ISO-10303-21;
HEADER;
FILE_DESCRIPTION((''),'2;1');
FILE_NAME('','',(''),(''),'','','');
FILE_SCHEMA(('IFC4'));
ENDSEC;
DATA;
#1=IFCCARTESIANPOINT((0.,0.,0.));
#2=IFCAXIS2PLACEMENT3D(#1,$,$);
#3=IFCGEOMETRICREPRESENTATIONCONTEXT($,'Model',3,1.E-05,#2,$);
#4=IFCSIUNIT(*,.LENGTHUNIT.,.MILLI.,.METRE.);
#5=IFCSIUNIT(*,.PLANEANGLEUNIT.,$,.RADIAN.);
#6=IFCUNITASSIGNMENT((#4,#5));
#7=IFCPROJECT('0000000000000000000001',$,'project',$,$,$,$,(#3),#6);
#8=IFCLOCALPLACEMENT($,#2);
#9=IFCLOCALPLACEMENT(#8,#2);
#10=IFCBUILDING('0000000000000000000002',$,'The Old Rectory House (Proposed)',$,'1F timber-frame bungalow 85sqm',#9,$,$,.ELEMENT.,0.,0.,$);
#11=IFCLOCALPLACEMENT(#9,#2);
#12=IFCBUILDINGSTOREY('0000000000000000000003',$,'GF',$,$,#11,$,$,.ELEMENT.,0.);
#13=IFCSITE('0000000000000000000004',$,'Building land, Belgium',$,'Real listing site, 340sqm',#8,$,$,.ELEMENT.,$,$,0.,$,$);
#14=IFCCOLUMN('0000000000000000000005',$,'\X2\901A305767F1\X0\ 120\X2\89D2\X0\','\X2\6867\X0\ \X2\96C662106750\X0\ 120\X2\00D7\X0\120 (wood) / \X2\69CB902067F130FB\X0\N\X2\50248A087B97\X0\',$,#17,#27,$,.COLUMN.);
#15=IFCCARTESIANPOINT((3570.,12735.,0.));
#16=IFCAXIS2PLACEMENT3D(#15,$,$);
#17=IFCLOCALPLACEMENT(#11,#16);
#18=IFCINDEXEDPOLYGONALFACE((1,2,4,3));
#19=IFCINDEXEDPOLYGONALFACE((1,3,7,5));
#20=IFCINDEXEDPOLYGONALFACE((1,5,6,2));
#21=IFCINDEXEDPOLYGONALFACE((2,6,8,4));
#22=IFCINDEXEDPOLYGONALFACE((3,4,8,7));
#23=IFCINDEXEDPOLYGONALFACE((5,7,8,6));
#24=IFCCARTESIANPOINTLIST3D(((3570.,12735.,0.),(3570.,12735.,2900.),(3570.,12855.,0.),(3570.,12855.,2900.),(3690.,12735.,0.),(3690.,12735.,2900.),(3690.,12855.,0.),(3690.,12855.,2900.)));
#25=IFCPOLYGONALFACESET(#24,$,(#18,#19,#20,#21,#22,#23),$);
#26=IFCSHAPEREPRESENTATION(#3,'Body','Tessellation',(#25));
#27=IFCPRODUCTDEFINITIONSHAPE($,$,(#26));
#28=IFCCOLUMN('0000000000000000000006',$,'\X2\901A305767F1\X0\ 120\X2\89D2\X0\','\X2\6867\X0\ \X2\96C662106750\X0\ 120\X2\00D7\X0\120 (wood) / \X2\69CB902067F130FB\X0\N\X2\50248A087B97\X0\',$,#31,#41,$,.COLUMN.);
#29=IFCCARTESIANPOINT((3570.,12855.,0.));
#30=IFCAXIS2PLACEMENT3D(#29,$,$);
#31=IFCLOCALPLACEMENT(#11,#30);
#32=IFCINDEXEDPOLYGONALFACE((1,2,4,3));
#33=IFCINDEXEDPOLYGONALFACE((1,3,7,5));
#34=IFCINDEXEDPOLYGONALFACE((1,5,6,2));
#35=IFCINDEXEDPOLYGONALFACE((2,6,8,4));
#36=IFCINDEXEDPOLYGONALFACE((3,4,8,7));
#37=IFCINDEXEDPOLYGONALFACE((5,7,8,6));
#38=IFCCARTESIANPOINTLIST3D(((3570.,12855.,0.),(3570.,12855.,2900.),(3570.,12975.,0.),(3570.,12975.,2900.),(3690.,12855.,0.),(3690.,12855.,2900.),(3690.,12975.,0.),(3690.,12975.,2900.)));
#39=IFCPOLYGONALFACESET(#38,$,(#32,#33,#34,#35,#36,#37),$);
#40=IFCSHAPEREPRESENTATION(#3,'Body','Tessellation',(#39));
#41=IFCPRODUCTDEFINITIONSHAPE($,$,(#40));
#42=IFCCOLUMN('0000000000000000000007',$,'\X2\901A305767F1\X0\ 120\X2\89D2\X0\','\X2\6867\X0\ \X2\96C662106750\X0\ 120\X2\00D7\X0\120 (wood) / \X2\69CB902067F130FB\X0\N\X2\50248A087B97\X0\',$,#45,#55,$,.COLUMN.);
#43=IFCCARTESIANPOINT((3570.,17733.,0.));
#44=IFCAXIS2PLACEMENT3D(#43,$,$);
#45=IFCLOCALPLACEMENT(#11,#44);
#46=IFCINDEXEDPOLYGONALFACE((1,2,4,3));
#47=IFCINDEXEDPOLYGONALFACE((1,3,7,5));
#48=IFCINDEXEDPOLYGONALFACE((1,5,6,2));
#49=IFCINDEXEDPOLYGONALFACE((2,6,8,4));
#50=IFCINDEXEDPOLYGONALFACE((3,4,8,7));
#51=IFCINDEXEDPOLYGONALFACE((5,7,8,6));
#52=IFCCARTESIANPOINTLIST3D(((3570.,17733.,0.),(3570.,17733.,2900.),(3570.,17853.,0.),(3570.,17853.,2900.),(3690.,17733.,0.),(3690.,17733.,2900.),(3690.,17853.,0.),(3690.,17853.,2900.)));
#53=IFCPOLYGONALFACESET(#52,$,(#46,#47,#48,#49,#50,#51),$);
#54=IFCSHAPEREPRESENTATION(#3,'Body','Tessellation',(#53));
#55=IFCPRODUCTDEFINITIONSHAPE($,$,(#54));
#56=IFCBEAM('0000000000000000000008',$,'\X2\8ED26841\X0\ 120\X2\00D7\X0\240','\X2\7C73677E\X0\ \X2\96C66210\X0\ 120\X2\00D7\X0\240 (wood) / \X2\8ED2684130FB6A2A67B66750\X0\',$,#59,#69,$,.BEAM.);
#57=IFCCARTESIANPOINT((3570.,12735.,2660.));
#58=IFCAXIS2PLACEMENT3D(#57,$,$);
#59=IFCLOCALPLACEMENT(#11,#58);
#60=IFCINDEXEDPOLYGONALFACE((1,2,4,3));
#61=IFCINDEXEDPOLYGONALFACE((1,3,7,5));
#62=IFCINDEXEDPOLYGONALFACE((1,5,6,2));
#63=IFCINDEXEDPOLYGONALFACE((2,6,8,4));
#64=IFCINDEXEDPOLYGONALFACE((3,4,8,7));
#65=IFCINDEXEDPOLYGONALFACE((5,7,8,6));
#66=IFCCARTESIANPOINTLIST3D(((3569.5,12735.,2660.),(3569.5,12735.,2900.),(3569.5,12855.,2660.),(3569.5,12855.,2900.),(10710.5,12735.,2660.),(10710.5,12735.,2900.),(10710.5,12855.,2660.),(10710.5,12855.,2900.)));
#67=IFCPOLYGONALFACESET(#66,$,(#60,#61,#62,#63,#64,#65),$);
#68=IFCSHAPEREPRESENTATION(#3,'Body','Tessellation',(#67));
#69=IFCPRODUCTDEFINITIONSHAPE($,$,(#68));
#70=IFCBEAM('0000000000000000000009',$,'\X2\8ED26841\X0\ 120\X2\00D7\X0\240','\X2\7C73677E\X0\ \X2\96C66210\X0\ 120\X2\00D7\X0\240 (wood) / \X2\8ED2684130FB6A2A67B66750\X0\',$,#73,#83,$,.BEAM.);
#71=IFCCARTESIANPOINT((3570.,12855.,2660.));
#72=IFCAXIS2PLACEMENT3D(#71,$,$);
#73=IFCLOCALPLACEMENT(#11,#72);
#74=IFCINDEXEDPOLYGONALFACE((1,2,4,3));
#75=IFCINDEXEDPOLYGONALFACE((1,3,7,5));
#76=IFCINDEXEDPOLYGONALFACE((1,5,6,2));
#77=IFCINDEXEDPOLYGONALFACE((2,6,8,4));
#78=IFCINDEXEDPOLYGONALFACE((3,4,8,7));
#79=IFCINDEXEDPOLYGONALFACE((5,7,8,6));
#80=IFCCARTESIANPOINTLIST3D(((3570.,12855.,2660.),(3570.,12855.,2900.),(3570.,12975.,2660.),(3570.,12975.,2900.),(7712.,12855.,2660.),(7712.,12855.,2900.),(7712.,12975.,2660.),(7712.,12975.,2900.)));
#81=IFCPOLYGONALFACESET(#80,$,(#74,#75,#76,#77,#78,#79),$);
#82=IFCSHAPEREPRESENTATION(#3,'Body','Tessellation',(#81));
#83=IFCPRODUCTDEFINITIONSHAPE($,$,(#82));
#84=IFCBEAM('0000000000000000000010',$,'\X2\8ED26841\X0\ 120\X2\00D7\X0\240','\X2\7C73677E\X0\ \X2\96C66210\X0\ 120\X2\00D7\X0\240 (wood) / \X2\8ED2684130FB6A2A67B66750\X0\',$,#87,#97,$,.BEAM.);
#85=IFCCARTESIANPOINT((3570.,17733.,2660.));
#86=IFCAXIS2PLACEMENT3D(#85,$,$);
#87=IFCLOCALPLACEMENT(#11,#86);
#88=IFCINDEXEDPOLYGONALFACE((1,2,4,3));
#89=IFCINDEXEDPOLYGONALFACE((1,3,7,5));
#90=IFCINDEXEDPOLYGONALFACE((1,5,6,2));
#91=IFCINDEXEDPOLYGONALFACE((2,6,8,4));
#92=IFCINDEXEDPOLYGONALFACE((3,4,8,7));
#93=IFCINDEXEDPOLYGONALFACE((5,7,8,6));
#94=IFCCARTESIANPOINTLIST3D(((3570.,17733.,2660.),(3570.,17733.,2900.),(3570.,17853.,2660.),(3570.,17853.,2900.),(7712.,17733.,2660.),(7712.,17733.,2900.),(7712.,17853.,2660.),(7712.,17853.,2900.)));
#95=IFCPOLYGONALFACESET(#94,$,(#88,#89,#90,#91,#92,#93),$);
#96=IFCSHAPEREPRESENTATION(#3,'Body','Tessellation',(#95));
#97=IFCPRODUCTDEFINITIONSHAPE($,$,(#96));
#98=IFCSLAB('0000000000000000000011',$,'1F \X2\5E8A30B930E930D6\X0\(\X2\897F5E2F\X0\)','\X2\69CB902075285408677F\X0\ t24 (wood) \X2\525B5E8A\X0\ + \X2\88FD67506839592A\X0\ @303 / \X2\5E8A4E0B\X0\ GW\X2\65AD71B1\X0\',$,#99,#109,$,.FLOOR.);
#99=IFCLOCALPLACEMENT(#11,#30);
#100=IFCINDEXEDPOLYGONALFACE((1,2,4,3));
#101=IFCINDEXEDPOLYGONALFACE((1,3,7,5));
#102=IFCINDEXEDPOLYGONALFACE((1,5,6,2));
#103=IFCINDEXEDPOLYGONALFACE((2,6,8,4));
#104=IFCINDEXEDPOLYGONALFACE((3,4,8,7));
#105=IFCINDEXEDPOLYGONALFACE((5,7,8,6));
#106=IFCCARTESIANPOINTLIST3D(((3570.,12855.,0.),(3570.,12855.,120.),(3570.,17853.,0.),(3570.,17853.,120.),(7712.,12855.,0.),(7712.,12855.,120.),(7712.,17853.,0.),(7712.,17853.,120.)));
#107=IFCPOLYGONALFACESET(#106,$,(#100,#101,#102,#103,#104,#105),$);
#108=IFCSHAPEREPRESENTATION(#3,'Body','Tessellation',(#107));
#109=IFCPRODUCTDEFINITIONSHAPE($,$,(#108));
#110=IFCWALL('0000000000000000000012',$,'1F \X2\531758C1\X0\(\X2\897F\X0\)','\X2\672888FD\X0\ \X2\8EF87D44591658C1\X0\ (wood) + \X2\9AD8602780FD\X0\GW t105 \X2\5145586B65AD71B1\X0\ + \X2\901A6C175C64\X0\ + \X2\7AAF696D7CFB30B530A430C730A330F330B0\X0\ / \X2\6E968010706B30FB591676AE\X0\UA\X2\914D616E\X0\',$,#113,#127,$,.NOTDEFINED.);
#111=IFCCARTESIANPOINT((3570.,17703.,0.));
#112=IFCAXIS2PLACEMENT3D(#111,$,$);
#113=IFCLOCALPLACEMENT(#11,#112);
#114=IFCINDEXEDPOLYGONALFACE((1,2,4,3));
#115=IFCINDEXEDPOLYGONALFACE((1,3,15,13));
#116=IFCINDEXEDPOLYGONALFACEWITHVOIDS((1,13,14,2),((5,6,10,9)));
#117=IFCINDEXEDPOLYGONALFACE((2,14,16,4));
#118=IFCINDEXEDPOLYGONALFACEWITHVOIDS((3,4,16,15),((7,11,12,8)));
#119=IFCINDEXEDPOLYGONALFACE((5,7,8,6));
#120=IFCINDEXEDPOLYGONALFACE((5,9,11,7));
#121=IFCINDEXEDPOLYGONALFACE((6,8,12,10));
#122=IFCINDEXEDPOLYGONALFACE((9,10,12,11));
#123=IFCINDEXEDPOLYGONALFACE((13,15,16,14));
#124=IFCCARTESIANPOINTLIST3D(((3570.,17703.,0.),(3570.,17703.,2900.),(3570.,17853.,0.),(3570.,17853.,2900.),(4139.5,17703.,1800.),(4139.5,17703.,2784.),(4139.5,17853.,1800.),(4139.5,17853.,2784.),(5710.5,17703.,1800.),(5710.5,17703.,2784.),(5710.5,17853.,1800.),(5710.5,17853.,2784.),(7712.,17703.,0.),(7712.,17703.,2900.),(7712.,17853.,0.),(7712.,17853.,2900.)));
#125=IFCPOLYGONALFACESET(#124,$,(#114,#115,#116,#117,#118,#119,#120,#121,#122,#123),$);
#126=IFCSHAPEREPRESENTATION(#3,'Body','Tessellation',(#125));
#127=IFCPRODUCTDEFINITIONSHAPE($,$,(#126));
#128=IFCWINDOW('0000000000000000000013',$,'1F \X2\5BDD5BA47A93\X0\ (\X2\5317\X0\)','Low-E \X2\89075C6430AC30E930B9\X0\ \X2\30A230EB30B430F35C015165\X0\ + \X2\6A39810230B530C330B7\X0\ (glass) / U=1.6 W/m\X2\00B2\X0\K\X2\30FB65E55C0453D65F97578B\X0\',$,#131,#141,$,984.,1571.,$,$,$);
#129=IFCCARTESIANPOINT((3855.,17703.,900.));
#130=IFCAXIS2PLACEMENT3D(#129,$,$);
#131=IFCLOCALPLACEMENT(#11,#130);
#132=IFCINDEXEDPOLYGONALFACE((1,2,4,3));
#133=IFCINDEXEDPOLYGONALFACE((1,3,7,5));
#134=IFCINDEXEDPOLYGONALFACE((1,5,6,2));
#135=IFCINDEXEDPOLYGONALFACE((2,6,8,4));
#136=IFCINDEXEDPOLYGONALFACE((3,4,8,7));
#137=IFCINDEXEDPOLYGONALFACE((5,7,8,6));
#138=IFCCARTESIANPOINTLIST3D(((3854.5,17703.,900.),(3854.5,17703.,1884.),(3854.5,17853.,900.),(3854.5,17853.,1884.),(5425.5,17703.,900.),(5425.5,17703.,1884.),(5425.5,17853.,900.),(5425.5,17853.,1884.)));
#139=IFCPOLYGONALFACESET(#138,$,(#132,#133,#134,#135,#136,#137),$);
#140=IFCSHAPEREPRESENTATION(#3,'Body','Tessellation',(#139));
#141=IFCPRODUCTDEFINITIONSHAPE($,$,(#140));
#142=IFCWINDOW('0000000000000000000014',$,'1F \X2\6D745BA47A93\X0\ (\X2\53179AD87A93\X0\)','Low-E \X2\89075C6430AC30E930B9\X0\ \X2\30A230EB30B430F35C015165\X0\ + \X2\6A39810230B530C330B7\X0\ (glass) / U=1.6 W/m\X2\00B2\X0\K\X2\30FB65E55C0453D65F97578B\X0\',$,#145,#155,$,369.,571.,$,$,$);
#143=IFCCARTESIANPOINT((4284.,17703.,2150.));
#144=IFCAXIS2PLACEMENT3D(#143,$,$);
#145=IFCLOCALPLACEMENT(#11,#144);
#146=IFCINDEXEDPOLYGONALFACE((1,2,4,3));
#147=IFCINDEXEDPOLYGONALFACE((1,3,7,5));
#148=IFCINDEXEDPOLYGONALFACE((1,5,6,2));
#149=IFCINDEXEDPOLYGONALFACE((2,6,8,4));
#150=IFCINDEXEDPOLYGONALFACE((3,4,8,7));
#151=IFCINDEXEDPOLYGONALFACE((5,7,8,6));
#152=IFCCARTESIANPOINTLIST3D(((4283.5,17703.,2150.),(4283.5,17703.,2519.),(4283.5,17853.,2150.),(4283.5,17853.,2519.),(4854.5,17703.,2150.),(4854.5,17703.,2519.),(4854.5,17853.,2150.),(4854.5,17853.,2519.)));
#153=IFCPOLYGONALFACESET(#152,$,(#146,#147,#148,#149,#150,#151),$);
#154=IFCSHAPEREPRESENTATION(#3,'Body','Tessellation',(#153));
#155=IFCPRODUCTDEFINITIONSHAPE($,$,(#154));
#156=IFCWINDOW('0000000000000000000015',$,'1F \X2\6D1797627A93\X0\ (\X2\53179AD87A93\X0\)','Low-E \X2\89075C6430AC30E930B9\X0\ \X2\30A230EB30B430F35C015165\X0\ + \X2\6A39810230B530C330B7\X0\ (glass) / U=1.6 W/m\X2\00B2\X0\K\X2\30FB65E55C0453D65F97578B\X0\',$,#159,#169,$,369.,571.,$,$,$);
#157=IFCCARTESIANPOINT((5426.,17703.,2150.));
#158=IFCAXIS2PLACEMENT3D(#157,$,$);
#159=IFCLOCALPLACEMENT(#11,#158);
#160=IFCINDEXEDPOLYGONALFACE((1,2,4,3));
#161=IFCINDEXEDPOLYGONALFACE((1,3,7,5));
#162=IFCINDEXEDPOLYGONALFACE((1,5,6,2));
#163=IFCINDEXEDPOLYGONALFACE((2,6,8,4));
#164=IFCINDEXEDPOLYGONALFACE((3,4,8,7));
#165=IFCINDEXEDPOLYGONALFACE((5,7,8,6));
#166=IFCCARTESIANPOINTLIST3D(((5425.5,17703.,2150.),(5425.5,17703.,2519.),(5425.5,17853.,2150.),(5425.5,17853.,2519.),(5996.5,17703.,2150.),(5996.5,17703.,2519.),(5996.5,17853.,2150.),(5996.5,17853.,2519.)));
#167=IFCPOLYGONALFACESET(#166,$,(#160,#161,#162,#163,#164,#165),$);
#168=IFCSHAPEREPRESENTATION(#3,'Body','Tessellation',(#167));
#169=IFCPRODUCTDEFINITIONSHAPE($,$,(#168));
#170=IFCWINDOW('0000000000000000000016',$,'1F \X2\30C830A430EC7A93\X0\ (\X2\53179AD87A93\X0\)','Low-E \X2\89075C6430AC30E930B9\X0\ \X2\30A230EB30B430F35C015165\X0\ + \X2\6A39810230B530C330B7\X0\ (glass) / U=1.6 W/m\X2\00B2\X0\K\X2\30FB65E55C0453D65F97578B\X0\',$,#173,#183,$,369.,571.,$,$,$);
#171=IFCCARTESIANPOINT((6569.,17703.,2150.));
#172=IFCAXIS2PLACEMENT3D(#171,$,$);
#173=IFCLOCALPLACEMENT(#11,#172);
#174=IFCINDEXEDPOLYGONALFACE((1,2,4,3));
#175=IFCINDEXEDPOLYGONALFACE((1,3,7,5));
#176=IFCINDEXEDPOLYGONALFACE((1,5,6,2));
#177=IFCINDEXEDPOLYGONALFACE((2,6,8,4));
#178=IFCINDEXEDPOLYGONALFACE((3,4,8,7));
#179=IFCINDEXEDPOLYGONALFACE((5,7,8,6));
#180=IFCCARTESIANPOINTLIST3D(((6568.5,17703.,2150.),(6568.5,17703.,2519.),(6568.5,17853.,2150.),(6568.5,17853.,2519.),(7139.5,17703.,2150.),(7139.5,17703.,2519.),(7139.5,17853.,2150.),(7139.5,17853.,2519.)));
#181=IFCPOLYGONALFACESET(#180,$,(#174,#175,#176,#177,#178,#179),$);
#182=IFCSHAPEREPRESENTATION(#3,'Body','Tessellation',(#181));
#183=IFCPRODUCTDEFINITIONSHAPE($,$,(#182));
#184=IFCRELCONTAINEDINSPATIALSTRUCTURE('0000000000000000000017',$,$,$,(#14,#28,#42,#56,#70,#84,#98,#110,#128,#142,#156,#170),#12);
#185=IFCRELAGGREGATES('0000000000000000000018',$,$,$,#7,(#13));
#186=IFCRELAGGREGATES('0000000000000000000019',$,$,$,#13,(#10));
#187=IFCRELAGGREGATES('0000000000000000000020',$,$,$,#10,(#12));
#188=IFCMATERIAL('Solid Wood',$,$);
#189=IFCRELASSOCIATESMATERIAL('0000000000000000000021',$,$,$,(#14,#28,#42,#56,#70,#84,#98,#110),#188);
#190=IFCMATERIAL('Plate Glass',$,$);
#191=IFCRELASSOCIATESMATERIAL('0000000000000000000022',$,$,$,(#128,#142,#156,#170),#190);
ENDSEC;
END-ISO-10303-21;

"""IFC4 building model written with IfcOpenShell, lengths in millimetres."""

from ifc_helpers import new_model, si_unit, frame, frame_2d, origin, place, context, project, spatial, rectangle, extrude, material, element, fill, save


model = new_model("IFC4")

# Units and contexts
model_context = context("Model", 3, precision=1e-05, world=origin())
ifc_project = project(units=[si_unit("LENGTHUNIT", "METRE", prefix="MILLI"), si_unit("PLANEANGLEUNIT", "RADIAN")], contexts=[model_context])

# Site, building, storey
site_placement = place(None, origin())
site = spatial("IfcSite", under=ifc_project, at=site_placement, Name="Building land, Belgium", ObjectType="Real listing site, 340sqm", CompositionType="ELEMENT", RefElevation=0.0)
building_placement = place(site_placement, origin())
building = spatial("IfcBuilding", under=site, at=building_placement, Name="The Old Rectory House (Proposed)", ObjectType="1F timber-frame bungalow 85sqm", CompositionType="ELEMENT", ElevationOfRefHeight=0.0, ElevationOfTerrain=0.0)
storey_placement = place(building_placement, origin())
storey = spatial("IfcBuildingStorey", under=building, at=storey_placement, Name="GF", CompositionType="ELEMENT", Elevation=0.0)

# Columns
ifc_material_1 = material(Name="Solid Wood")
column_1_placement = place(storey_placement, frame((3570.0, 12735.0, 0.0)))
element("IfcColumn", 1, at=column_1_placement, inside=storey, material=ifc_material_1, Name="通し柱 120角", Description="桧 集成材 120×120 (wood) / 構造柱・N値計算", PredefinedType="COLUMN", context=model_context, shape_type="SweptSolid", body=[
    extrude(rectangle(XDim=120.0, YDim=120.0, at=frame_2d((60.0, 60.0))), frame((3570.0, 12735.0, 0.0)), (0.0, 0.0, 1.0), 2900.0),
])
column_2_placement = place(storey_placement, frame((3570.0, 12855.0, 0.0)))
element("IfcColumn", 2, at=column_2_placement, inside=storey, material=ifc_material_1, Name="通し柱 120角", Description="桧 集成材 120×120 (wood) / 構造柱・N値計算", PredefinedType="COLUMN", context=model_context, shape_type="SweptSolid", body=[
    extrude(rectangle(XDim=120.0, YDim=120.0, at=frame_2d((60.0, 60.0))), frame((3570.0, 12855.0, 0.0)), (0.0, 0.0, 1.0), 2900.0),
])
column_3_placement = place(storey_placement, frame((3570.0, 17733.0, 0.0)))
element("IfcColumn", 3, at=column_3_placement, inside=storey, material=ifc_material_1, Name="通し柱 120角", Description="桧 集成材 120×120 (wood) / 構造柱・N値計算", PredefinedType="COLUMN", context=model_context, shape_type="SweptSolid", body=[
    extrude(rectangle(XDim=120.0, YDim=120.0, at=frame_2d((60.0, 60.0))), frame((3570.0, 17733.0, 0.0)), (0.0, 0.0, 1.0), 2900.0),
])

# Beams
beam_1_placement = place(storey_placement, frame((3570.0, 12735.0, 2660.0)))
element("IfcBeam", 4, at=beam_1_placement, inside=storey, material=ifc_material_1, Name="軒桁 120×240", Description="米松 集成 120×240 (wood) / 軒桁・横架材", PredefinedType="BEAM", context=model_context, shape_type="SweptSolid", body=[
    extrude(rectangle(XDim=7141.0, YDim=120.0, at=frame_2d((3570.0, 60.0))), frame((3570.0, 12735.0, 2660.0)), (0.0, 0.0, 1.0), 240.0),
])
beam_2_placement = place(storey_placement, frame((3570.0, 12855.0, 2660.0)))
element("IfcBeam", 5, at=beam_2_placement, inside=storey, material=ifc_material_1, Name="軒桁 120×240", Description="米松 集成 120×240 (wood) / 軒桁・横架材", PredefinedType="BEAM", context=model_context, shape_type="SweptSolid", body=[
    extrude(rectangle(XDim=4142.0, YDim=120.0, at=frame_2d((2071.0, 60.0))), frame((3570.0, 12855.0, 2660.0)), (0.0, 0.0, 1.0), 240.0),
])
beam_3_placement = place(storey_placement, frame((3570.0, 17733.0, 2660.0)))
element("IfcBeam", 6, at=beam_3_placement, inside=storey, material=ifc_material_1, Name="軒桁 120×240", Description="米松 集成 120×240 (wood) / 軒桁・横架材", PredefinedType="BEAM", context=model_context, shape_type="SweptSolid", body=[
    extrude(rectangle(XDim=4142.0, YDim=120.0, at=frame_2d((2071.0, 60.0))), frame((3570.0, 17733.0, 2660.0)), (0.0, 0.0, 1.0), 240.0),
])

# Slab
slab_placement = place(storey_placement, frame((3570.0, 12855.0, 0.0)))
element("IfcSlab", 7, at=slab_placement, inside=storey, material=ifc_material_1, Name="1F 床スラブ(西帯)", Description="構造用合板 t24 (wood) 剛床 + 製材根太 @303 / 床下 GW断熱", PredefinedType="FLOOR", context=model_context, shape_type="SweptSolid", body=[
    extrude(rectangle(XDim=4142.0, YDim=4998.0, at=frame_2d((2071.0, 2499.0))), frame((3570.0, 12855.0, 0.0)), (0.0, 0.0, 1.0), 120.0),
])

# Wall, openings, windows
wall_1_placement = place(storey_placement, frame((3570.0, 17703.0, 0.0)))
wall_1 = element("IfcWall", 8, at=wall_1_placement, inside=storey, material=ifc_material_1, Name="1F 北壁(西)", Description="木製 軸組外壁 (wood) + 高性能GW t105 充填断熱 + 通気層 + 窯業系サイディング / 準耐火・外皮UA配慮", PredefinedType="NOTDEFINED", context=model_context, shape_type="SweptSolid", body=[
    extrude(rectangle(XDim=4142.0, YDim=150.0, at=frame_2d((2071.0, 75.0))), frame((3570.0, 17703.0, 0.0)), (0.0, 0.0, 1.0), 2900.0),
])
opening_1_placement = place(storey_placement, frame((3855.0, 17703.0, 900.0)))
opening_1 = element("IfcOpeningElement", 9, at=opening_1_placement, cuts=wall_1, PredefinedType="NOTDEFINED", context=model_context, shape_type="SweptSolid", body=[
    extrude(rectangle(XDim=1571.0, YDim=150.0, at=frame_2d((785.0, 75.0))), frame((3855.0, 17703.0, 900.0)), (0.0, 0.0, 1.0), 984.0),
])
opening_2_placement = place(storey_placement, frame((4284.0, 17703.0, 2150.0)))
opening_2 = element("IfcOpeningElement", 10, at=opening_2_placement, cuts=wall_1, PredefinedType="NOTDEFINED", context=model_context, shape_type="SweptSolid", body=[
    extrude(rectangle(XDim=571.0, YDim=150.0, at=frame_2d((285.0, 75.0))), frame((4284.0, 17703.0, 2150.0)), (0.0, 0.0, 1.0), 369.0),
])
opening_3_placement = place(storey_placement, frame((5426.0, 17703.0, 2150.0)))
opening_3 = element("IfcOpeningElement", 11, at=opening_3_placement, cuts=wall_1, PredefinedType="NOTDEFINED", context=model_context, shape_type="SweptSolid", body=[
    extrude(rectangle(XDim=571.0, YDim=150.0, at=frame_2d((285.0, 75.0))), frame((5426.0, 17703.0, 2150.0)), (0.0, 0.0, 1.0), 369.0),
])
opening_4_placement = place(storey_placement, frame((6569.0, 17703.0, 2150.0)))
opening_4 = element("IfcOpeningElement", 12, at=opening_4_placement, cuts=wall_1, PredefinedType="NOTDEFINED", context=model_context, shape_type="SweptSolid", body=[
    extrude(rectangle(XDim=571.0, YDim=150.0, at=frame_2d((285.0, 75.0))), frame((6569.0, 17703.0, 2150.0)), (0.0, 0.0, 1.0), 369.0),
])
ifc_material_2 = material(Name="Plate Glass")
window_1_placement = place(storey_placement, frame((3855.0, 17703.0, 900.0)))
window_1 = element("IfcWindow", 13, at=window_1_placement, inside=storey, material=ifc_material_2, Name="1F 寝室窓 (北)", Description="Low-E 複層ガラス アルゴン封入 + 樹脂サッシ (glass) / U=1.6 W/m²K・日射取得型", OverallHeight=984.0, OverallWidth=1571.0, context=model_context, shape_type="SweptSolid", body=[
    extrude(rectangle(XDim=1571.0, YDim=150.0, at=frame_2d((785.0, 75.0))), frame((3855.0, 17703.0, 900.0)), (0.0, 0.0, 1.0), 984.0),
])
fill(opening_1, window_1)
window_2_placement = place(storey_placement, frame((4284.0, 17703.0, 2150.0)))
window_2 = element("IfcWindow", 14, at=window_2_placement, inside=storey, material=ifc_material_2, Name="1F 浴室窓 (北高窓)", Description="Low-E 複層ガラス アルゴン封入 + 樹脂サッシ (glass) / U=1.6 W/m²K・日射取得型", OverallHeight=369.0, OverallWidth=571.0, context=model_context, shape_type="SweptSolid", body=[
    extrude(rectangle(XDim=571.0, YDim=150.0, at=frame_2d((285.0, 75.0))), frame((4284.0, 17703.0, 2150.0)), (0.0, 0.0, 1.0), 369.0),
])
fill(opening_2, window_2)
window_3_placement = place(storey_placement, frame((5426.0, 17703.0, 2150.0)))
window_3 = element("IfcWindow", 15, at=window_3_placement, inside=storey, material=ifc_material_2, Name="1F 洗面窓 (北高窓)", Description="Low-E 複層ガラス アルゴン封入 + 樹脂サッシ (glass) / U=1.6 W/m²K・日射取得型", OverallHeight=369.0, OverallWidth=571.0, context=model_context, shape_type="SweptSolid", body=[
    extrude(rectangle(XDim=571.0, YDim=150.0, at=frame_2d((285.0, 75.0))), frame((5426.0, 17703.0, 2150.0)), (0.0, 0.0, 1.0), 369.0),
])
fill(opening_3, window_3)
window_4_placement = place(storey_placement, frame((6569.0, 17703.0, 2150.0)))
window_4 = element("IfcWindow", 16, at=window_4_placement, inside=storey, material=ifc_material_2, Name="1F トイレ窓 (北高窓)", Description="Low-E 複層ガラス アルゴン封入 + 樹脂サッシ (glass) / U=1.6 W/m²K・日射取得型", OverallHeight=369.0, OverallWidth=571.0, context=model_context, shape_type="SweptSolid", body=[
    extrude(rectangle(XDim=571.0, YDim=150.0, at=frame_2d((285.0, 75.0))), frame((6569.0, 17703.0, 2150.0)), (0.0, 0.0, 1.0), 369.0),
])
fill(opening_4, window_4)

save(model, "model.ifc")
